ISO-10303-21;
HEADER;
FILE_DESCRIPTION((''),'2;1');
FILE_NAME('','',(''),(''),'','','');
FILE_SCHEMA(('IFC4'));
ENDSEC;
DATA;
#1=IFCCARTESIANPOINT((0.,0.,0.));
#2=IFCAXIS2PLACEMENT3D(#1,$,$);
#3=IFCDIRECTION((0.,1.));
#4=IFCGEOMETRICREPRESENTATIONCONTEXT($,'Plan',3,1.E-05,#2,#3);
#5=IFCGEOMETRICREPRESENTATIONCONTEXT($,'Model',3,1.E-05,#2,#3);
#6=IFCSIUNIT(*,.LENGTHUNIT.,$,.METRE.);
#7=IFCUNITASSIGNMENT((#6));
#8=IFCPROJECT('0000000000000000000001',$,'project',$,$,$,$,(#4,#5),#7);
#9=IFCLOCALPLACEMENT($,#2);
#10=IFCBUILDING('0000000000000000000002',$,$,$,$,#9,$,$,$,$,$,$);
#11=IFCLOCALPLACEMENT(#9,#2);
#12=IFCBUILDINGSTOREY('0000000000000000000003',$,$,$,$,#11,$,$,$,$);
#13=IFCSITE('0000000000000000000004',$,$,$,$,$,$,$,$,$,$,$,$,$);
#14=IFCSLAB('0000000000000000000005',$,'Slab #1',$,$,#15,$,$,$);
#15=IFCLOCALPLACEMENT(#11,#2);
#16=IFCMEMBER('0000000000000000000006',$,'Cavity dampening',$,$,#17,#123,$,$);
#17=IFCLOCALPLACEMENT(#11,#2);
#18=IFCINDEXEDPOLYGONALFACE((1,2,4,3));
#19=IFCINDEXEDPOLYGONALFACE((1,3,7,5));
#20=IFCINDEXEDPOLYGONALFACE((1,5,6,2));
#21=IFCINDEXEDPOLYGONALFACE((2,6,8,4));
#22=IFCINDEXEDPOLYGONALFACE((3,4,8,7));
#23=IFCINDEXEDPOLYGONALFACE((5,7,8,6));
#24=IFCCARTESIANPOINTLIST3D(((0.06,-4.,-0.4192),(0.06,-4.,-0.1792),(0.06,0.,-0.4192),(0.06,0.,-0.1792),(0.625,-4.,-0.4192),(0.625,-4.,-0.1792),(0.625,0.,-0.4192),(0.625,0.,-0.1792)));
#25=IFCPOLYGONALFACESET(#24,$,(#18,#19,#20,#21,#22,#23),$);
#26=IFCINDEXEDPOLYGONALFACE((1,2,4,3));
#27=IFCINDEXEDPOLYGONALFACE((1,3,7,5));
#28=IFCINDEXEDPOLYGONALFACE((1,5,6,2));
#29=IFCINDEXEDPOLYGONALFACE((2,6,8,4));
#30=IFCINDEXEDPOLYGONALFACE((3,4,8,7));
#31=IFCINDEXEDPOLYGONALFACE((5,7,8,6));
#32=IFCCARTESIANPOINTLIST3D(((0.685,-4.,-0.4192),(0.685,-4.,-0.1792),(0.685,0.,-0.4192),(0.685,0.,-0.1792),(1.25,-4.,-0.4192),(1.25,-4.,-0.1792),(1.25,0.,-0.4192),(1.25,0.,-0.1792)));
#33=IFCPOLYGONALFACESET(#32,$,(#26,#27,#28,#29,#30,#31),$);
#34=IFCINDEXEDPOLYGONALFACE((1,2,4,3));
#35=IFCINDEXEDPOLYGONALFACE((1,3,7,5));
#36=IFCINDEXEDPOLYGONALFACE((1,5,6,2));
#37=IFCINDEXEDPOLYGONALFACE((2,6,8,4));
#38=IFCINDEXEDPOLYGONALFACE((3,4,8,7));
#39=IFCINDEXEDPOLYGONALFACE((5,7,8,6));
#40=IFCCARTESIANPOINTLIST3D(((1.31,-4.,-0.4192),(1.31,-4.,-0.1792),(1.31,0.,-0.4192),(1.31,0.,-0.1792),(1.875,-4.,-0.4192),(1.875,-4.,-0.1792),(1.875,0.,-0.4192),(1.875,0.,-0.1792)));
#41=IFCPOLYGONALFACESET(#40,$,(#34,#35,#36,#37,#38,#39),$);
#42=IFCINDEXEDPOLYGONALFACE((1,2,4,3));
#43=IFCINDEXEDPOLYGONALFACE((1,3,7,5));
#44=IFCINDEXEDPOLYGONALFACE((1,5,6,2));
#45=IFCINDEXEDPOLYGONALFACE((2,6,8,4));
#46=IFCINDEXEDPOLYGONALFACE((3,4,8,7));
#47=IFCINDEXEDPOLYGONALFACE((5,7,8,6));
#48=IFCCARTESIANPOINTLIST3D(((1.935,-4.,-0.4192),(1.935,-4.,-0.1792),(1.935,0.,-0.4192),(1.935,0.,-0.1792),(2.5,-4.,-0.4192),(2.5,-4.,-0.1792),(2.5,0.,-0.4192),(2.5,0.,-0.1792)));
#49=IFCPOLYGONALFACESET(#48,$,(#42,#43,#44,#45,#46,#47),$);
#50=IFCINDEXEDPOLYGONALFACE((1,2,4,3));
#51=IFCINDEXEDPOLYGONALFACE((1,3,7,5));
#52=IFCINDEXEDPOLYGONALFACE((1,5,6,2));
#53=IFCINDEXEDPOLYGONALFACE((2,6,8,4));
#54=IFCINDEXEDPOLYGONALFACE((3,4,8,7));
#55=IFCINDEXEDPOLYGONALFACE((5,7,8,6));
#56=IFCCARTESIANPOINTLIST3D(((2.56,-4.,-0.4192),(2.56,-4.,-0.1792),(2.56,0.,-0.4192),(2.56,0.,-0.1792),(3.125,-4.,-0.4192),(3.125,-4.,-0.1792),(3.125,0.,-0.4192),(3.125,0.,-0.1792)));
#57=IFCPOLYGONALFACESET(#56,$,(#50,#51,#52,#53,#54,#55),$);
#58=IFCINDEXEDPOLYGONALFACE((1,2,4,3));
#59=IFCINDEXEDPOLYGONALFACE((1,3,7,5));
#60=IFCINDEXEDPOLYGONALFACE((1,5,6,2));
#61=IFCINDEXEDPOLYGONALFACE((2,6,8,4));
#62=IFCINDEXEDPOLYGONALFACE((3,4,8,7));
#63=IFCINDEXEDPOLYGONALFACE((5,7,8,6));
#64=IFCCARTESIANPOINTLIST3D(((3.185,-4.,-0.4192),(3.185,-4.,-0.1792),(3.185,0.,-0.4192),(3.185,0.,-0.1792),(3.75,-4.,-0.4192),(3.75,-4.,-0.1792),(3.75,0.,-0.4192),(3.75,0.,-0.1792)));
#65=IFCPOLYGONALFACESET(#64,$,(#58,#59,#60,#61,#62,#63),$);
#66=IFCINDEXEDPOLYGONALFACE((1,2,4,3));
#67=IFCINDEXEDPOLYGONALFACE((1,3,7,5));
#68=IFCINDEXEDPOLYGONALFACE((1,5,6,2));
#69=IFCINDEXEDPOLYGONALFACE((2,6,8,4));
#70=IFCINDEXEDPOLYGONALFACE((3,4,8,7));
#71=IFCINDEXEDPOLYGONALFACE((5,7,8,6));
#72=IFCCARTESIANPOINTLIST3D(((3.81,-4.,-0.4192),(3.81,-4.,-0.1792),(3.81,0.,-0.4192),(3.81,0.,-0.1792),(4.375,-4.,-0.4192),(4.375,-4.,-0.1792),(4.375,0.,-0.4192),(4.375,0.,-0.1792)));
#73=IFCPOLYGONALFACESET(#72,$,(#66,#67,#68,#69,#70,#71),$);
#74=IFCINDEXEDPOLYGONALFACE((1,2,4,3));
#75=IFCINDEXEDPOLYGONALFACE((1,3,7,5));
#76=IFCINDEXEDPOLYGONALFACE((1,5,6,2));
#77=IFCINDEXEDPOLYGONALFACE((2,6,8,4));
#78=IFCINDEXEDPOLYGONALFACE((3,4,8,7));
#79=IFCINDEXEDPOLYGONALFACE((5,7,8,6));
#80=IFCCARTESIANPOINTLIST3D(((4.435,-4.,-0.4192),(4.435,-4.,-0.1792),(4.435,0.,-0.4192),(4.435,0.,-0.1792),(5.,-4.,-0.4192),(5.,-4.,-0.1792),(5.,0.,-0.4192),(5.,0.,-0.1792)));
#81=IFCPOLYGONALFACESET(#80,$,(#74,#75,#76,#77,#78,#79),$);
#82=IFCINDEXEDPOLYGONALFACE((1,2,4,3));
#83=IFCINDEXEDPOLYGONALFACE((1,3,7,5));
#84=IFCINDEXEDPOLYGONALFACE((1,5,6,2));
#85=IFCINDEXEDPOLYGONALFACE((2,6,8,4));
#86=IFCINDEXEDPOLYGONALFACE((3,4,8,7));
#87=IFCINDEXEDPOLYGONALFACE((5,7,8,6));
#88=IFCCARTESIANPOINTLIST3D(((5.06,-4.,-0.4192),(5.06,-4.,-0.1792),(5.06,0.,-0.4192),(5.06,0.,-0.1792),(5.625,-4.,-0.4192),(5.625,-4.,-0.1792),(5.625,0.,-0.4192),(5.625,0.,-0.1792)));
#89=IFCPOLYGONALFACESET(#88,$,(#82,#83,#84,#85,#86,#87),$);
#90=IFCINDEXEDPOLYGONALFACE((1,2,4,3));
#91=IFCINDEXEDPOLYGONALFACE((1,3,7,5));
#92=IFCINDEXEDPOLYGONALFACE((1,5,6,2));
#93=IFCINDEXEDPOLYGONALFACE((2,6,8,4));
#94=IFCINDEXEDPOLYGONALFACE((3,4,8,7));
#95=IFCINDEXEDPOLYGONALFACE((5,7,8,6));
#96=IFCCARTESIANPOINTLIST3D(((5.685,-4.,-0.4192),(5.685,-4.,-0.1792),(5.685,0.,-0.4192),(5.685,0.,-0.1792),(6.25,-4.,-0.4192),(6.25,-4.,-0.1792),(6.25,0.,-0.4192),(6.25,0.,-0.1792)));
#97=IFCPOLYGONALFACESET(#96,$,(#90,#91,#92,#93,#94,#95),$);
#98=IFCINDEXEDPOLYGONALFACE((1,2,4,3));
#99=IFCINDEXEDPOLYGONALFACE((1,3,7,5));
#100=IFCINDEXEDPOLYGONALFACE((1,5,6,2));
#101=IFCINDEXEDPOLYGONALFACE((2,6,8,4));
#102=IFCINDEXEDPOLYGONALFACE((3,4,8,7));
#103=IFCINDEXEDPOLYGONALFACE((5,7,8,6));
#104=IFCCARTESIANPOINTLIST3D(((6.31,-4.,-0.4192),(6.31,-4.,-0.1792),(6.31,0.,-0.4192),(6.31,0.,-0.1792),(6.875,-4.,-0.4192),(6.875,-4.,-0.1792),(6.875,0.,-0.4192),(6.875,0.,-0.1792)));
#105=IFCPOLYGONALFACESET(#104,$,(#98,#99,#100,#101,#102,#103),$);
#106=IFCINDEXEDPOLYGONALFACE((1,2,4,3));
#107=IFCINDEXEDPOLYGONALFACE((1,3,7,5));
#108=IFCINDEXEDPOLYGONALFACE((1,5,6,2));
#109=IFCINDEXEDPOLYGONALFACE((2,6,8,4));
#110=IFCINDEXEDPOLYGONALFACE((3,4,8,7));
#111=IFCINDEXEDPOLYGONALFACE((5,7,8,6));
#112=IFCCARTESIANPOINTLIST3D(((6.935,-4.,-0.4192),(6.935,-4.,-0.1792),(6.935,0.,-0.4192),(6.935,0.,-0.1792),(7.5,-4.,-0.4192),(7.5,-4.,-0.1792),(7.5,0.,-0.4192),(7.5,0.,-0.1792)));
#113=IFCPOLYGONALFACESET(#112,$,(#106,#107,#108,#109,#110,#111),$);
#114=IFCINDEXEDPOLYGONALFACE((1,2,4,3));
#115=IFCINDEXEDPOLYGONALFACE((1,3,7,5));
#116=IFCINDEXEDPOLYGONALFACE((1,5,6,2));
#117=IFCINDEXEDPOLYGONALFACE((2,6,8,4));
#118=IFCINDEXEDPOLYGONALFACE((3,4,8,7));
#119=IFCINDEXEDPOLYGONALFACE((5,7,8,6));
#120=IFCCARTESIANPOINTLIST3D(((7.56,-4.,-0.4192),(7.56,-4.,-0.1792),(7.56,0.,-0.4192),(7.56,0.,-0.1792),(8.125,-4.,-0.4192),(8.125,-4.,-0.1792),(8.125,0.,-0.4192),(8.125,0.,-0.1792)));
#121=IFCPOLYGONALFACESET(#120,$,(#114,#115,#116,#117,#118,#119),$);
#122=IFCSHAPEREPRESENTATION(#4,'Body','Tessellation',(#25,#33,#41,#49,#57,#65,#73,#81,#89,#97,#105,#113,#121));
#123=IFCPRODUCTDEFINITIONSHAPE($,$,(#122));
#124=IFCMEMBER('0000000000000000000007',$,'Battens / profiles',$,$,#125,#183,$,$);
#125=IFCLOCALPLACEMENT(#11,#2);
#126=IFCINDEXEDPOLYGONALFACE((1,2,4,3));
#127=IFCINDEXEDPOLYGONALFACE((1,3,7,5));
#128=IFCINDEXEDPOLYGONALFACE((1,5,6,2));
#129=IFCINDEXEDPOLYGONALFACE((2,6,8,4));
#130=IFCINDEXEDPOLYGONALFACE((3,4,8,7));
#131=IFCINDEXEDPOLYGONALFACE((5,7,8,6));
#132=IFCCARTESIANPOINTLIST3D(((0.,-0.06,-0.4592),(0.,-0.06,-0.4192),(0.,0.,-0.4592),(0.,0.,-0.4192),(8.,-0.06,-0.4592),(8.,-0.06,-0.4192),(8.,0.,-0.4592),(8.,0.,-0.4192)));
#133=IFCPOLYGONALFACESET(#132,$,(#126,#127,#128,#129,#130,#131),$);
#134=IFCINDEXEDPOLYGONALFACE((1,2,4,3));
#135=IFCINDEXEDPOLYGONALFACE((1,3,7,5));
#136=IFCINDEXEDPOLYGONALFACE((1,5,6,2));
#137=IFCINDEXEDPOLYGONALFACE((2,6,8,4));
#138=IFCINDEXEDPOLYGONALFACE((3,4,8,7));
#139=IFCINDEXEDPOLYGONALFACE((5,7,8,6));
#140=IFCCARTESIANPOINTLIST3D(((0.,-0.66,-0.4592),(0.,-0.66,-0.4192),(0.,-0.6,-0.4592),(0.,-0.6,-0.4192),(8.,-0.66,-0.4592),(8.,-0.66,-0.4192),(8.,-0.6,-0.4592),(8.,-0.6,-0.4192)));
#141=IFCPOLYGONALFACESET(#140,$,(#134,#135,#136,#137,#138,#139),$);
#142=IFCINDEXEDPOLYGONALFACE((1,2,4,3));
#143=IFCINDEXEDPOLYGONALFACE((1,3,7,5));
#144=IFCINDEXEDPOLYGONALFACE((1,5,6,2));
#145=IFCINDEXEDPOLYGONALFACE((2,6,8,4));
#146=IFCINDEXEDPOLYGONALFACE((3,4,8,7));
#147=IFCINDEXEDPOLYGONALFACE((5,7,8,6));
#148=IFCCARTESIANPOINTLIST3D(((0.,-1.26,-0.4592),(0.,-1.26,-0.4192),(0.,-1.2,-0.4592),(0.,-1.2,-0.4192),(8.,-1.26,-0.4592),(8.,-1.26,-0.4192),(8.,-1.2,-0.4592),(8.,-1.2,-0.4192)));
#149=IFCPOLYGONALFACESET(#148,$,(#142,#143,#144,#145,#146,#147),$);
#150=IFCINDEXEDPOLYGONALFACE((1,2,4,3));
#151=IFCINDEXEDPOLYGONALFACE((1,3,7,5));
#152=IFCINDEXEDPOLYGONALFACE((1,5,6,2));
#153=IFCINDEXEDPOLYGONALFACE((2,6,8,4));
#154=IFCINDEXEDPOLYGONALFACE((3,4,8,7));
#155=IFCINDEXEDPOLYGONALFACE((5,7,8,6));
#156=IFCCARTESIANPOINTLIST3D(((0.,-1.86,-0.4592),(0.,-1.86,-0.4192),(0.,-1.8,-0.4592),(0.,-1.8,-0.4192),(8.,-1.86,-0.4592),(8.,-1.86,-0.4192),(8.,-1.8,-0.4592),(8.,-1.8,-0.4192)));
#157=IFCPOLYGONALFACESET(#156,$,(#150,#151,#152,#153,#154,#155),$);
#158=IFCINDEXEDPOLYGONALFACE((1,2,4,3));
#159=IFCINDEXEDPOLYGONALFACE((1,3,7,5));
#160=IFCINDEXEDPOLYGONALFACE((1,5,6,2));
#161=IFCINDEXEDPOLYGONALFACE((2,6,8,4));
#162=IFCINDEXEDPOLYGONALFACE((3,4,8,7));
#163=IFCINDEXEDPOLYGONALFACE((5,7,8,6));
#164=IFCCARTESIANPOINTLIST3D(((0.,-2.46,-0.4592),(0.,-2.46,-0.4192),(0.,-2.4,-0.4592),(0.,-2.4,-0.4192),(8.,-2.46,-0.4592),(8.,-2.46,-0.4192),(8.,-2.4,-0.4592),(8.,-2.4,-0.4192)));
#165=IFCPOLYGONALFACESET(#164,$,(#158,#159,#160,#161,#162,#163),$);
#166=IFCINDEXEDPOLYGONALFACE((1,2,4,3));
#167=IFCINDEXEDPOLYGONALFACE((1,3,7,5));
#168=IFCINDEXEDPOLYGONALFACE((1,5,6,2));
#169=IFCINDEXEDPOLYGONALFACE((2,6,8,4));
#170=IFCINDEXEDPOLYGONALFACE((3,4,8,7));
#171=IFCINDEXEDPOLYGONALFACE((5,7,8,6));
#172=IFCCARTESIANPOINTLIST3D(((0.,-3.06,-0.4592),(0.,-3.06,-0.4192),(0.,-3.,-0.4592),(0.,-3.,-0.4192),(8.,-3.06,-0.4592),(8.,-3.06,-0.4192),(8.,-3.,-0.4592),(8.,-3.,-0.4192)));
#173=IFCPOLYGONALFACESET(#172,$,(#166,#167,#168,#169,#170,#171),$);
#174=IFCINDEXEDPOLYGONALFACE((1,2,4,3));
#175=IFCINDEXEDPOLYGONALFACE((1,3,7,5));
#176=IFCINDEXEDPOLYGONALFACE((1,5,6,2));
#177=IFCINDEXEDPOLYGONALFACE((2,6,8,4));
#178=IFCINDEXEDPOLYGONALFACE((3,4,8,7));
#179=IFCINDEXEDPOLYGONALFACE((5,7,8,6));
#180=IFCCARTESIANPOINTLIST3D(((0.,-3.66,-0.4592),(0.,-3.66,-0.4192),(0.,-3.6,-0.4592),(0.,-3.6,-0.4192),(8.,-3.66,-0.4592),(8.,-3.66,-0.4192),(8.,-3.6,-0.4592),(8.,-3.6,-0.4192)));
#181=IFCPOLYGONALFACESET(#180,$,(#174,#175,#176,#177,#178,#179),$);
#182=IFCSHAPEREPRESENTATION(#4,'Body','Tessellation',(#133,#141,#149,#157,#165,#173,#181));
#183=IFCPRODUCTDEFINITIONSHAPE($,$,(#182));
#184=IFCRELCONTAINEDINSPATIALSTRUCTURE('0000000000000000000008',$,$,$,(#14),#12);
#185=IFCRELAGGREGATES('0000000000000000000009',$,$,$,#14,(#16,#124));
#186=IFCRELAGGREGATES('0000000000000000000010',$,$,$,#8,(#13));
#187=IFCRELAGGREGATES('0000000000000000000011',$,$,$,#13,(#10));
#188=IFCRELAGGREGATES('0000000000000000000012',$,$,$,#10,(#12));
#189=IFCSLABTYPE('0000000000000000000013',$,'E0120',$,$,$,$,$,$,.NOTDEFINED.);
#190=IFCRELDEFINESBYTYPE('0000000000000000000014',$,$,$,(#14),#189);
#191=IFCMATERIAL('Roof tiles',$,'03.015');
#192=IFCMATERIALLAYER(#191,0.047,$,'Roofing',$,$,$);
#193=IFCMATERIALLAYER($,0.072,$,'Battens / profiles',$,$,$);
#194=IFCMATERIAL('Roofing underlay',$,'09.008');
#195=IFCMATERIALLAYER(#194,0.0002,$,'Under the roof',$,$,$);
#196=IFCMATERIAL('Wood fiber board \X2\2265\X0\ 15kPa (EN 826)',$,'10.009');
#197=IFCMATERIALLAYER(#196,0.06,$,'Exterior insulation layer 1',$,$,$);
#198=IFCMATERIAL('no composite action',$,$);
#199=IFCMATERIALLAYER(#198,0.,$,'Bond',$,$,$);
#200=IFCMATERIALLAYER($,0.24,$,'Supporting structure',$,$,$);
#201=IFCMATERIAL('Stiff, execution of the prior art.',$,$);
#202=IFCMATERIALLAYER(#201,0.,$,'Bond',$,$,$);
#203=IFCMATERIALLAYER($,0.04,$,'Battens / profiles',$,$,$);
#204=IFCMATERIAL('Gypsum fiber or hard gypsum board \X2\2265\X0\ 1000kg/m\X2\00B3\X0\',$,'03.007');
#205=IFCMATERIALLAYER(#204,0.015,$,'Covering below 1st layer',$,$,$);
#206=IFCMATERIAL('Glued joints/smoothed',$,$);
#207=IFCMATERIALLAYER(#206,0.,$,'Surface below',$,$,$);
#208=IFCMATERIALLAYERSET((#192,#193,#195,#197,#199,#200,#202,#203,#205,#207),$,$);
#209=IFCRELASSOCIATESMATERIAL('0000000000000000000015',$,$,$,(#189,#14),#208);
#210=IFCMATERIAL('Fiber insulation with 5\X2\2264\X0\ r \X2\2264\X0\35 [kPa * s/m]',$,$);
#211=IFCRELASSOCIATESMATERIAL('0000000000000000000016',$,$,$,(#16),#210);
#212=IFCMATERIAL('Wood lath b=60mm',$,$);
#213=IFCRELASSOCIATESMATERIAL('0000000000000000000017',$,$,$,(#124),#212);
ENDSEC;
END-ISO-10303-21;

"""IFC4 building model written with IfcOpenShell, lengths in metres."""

from ifc_helpers import new_model, si_unit, direction, frame, frame_2d, origin, place, context, project, spatial, rectangle, extrude, material, layer, layer_set, type_object, element, aggregate, save


model = new_model("IFC4")

# Units and contexts
plan_context = context("Plan", 3, precision=1e-05, world=origin(), true_north=direction((0.0, 1.0)))
model_context = context("Model", 3, precision=1e-05, world=origin(), true_north=direction((0.0, 1.0)))
ifc_project = project(units=[si_unit("LENGTHUNIT", "METRE")], contexts=[plan_context, model_context])

# Site, building, storey
site = spatial("IfcSite", under=ifc_project)
building_placement = place(None, origin())
building = spatial("IfcBuilding", under=site, at=building_placement)
storey_placement = place(building_placement, origin())
storey = spatial("IfcBuildingStorey", under=building, at=storey_placement)

# Slab, members
ifc_material_1 = material(Name="Roof tiles", Category="03.015")
ifc_layer_1 = layer(ifc_material_1, 0.047, Name="Roofing")
ifc_layer_2 = layer(None, 0.072, Name="Battens / profiles")
ifc_material_2 = material(Name="Roofing underlay", Category="09.008")
ifc_layer_3 = layer(ifc_material_2, 0.0002, Name="Under the roof")
ifc_material_3 = material(Name="Wood fiber board ≥ 15kPa (EN 826)", Category="10.009")
ifc_layer_4 = layer(ifc_material_3, 0.06, Name="Exterior insulation layer 1")
ifc_material_4 = material(Name="no composite action")
ifc_layer_5 = layer(ifc_material_4, 0.0, Name="Bond")
ifc_layer_6 = layer(None, 0.24, Name="Supporting structure")
ifc_material_5 = material(Name="Stiff, execution of the prior art.")
ifc_layer_7 = layer(ifc_material_5, 0.0, Name="Bond")
ifc_layer_8 = layer(None, 0.04, Name="Battens / profiles")
ifc_material_6 = material(Name="Gypsum fiber or hard gypsum board ≥ 1000kg/m³", Category="03.007")
ifc_layer_9 = layer(ifc_material_6, 0.015, Name="Covering below 1st layer")
ifc_material_7 = material(Name="Glued joints/smoothed")
ifc_layer_10 = layer(ifc_material_7, 0.0, Name="Surface below")
ifc_layer_set = layer_set([ifc_layer_1, ifc_layer_2, ifc_layer_3, ifc_layer_4, ifc_layer_5, ifc_layer_6, ifc_layer_7, ifc_layer_8, ifc_layer_9, ifc_layer_10])
slab_type = type_object("IfcSlabType", Name="E0120", PredefinedType="NOTDEFINED", material=ifc_layer_set)
slab_placement = place(None, frame((0.0, 0.0, 0.0), z_axis=(0.0, 0.0, -1.0), x_axis=(1.0, 0.0, 0.0)))
slab = element("IfcSlab", 1, at=slab_placement, inside=storey, type_object=slab_type, material=ifc_layer_set, Name="Slab #1")
ifc_material_8 = material(Name="Fiber insulation with 5≤ r ≤35 [kPa * s/m]")
member_1_placement = place(slab_placement, origin())
member_1 = element("IfcMember", 2, at=member_1_placement, material=ifc_material_8, Name="Cavity dampening", context=plan_context, shape_type="SweptSolid", body=[
    extrude(rectangle(XDim=0.565, YDim=0.24, at=frame_2d((0.2825, 0.12), x_axis=(1.0, 0.0))), frame((0.06, 4.0, 0.1792), z_axis=(0.0, -1.0, 0.0), x_axis=(1.0, 0.0, 0.0)), (0.0, 0.0, 1.0), 4.0),
    extrude(rectangle(XDim=0.565, YDim=0.24, at=frame_2d((0.2825, 0.12), x_axis=(1.0, 0.0))), frame((0.685, 4.0, 0.1792), z_axis=(0.0, -1.0, 0.0), x_axis=(1.0, 0.0, 0.0)), (0.0, 0.0, 1.0), 4.0),
    extrude(rectangle(XDim=0.565, YDim=0.24, at=frame_2d((0.2825, 0.12), x_axis=(1.0, 0.0))), frame((1.31, 4.0, 0.1792), z_axis=(0.0, -1.0, 0.0), x_axis=(1.0, 0.0, 0.0)), (0.0, 0.0, 1.0), 4.0),
    extrude(rectangle(XDim=0.565, YDim=0.24, at=frame_2d((0.2825, 0.12), x_axis=(1.0, 0.0))), frame((1.935, 4.0, 0.1792), z_axis=(0.0, -1.0, 0.0), x_axis=(1.0, 0.0, 0.0)), (0.0, 0.0, 1.0), 4.0),
    extrude(rectangle(XDim=0.565, YDim=0.24, at=frame_2d((0.2825, 0.12), x_axis=(1.0, 0.0))), frame((2.56, 4.0, 0.1792), z_axis=(0.0, -1.0, 0.0), x_axis=(1.0, 0.0, 0.0)), (0.0, 0.0, 1.0), 4.0),
    extrude(rectangle(XDim=0.565, YDim=0.24, at=frame_2d((0.2825, 0.12), x_axis=(1.0, 0.0))), frame((3.185, 4.0, 0.1792), z_axis=(0.0, -1.0, 0.0), x_axis=(1.0, 0.0, 0.0)), (0.0, 0.0, 1.0), 4.0),
    extrude(rectangle(XDim=0.565, YDim=0.24, at=frame_2d((0.2825, 0.12), x_axis=(1.0, 0.0))), frame((3.81, 4.0, 0.1792), z_axis=(0.0, -1.0, 0.0), x_axis=(1.0, 0.0, 0.0)), (0.0, 0.0, 1.0), 4.0),
    extrude(rectangle(XDim=0.565, YDim=0.24, at=frame_2d((0.2825, 0.12), x_axis=(1.0, 0.0))), frame((4.435, 4.0, 0.1792), z_axis=(0.0, -1.0, 0.0), x_axis=(1.0, 0.0, 0.0)), (0.0, 0.0, 1.0), 4.0),
    extrude(rectangle(XDim=0.565, YDim=0.24, at=frame_2d((0.2825, 0.12), x_axis=(1.0, 0.0))), frame((5.06, 4.0, 0.1792), z_axis=(0.0, -1.0, 0.0), x_axis=(1.0, 0.0, 0.0)), (0.0, 0.0, 1.0), 4.0),
    extrude(rectangle(XDim=0.565, YDim=0.24, at=frame_2d((0.2825, 0.12), x_axis=(1.0, 0.0))), frame((5.685, 4.0, 0.1792), z_axis=(0.0, -1.0, 0.0), x_axis=(1.0, 0.0, 0.0)), (0.0, 0.0, 1.0), 4.0),
    extrude(rectangle(XDim=0.565, YDim=0.24, at=frame_2d((0.2825, 0.12), x_axis=(1.0, 0.0))), frame((6.31, 4.0, 0.1792), z_axis=(0.0, -1.0, 0.0), x_axis=(1.0, 0.0, 0.0)), (0.0, 0.0, 1.0), 4.0),
    extrude(rectangle(XDim=0.565, YDim=0.24, at=frame_2d((0.2825, 0.12), x_axis=(1.0, 0.0))), frame((6.935, 4.0, 0.1792), z_axis=(0.0, -1.0, 0.0), x_axis=(1.0, 0.0, 0.0)), (0.0, 0.0, 1.0), 4.0),
    extrude(rectangle(XDim=0.565, YDim=0.24, at=frame_2d((0.2825, 0.12), x_axis=(1.0, 0.0))), frame((7.56, 4.0, 0.1792), z_axis=(0.0, -1.0, 0.0), x_axis=(1.0, 0.0, 0.0)), (0.0, 0.0, 1.0), 4.0),
])
ifc_material_9 = material(Name="Wood lath b=60mm")
member_2_placement = place(slab_placement, origin())
member_2 = element("IfcMember", 3, at=member_2_placement, material=ifc_material_9, Name="Battens / profiles", context=plan_context, shape_type="SweptSolid", body=[
    extrude(rectangle(XDim=0.06, YDim=0.04, at=frame_2d((0.03, 0.02), x_axis=(1.0, 0.0))), frame((0.0, 0.0, 0.4192), z_axis=(1.0, 0.0, 0.0), x_axis=(0.0, 1.0, 0.0)), (0.0, 0.0, 1.0), 8.0),
    extrude(rectangle(XDim=0.06, YDim=0.04, at=frame_2d((0.03, 0.02), x_axis=(1.0, 0.0))), frame((0.0, 0.6, 0.4192), z_axis=(1.0, 0.0, 0.0), x_axis=(0.0, 1.0, 0.0)), (0.0, 0.0, 1.0), 8.0),
    extrude(rectangle(XDim=0.06, YDim=0.04, at=frame_2d((0.03, 0.02), x_axis=(1.0, 0.0))), frame((0.0, 1.2, 0.4192), z_axis=(1.0, 0.0, 0.0), x_axis=(0.0, 1.0, 0.0)), (0.0, 0.0, 1.0), 8.0),
    extrude(rectangle(XDim=0.06, YDim=0.04, at=frame_2d((0.03, 0.02), x_axis=(1.0, 0.0))), frame((0.0, 1.8, 0.4192), z_axis=(1.0, 0.0, 0.0), x_axis=(0.0, 1.0, 0.0)), (0.0, 0.0, 1.0), 8.0),
    extrude(rectangle(XDim=0.06, YDim=0.04, at=frame_2d((0.03, 0.02), x_axis=(1.0, 0.0))), frame((0.0, 2.4, 0.4192), z_axis=(1.0, 0.0, 0.0), x_axis=(0.0, 1.0, 0.0)), (0.0, 0.0, 1.0), 8.0),
    extrude(rectangle(XDim=0.06, YDim=0.04, at=frame_2d((0.03, 0.02), x_axis=(1.0, 0.0))), frame((0.0, 3.0, 0.4192), z_axis=(1.0, 0.0, 0.0), x_axis=(0.0, 1.0, 0.0)), (0.0, 0.0, 1.0), 8.0),
    extrude(rectangle(XDim=0.06, YDim=0.04, at=frame_2d((0.03, 0.02), x_axis=(1.0, 0.0))), frame((0.0, 3.6, 0.4192), z_axis=(1.0, 0.0, 0.0), x_axis=(0.0, 1.0, 0.0)), (0.0, 0.0, 1.0), 8.0),
])
aggregate(slab, [member_1, member_2])

save(model, "model.ifc")
